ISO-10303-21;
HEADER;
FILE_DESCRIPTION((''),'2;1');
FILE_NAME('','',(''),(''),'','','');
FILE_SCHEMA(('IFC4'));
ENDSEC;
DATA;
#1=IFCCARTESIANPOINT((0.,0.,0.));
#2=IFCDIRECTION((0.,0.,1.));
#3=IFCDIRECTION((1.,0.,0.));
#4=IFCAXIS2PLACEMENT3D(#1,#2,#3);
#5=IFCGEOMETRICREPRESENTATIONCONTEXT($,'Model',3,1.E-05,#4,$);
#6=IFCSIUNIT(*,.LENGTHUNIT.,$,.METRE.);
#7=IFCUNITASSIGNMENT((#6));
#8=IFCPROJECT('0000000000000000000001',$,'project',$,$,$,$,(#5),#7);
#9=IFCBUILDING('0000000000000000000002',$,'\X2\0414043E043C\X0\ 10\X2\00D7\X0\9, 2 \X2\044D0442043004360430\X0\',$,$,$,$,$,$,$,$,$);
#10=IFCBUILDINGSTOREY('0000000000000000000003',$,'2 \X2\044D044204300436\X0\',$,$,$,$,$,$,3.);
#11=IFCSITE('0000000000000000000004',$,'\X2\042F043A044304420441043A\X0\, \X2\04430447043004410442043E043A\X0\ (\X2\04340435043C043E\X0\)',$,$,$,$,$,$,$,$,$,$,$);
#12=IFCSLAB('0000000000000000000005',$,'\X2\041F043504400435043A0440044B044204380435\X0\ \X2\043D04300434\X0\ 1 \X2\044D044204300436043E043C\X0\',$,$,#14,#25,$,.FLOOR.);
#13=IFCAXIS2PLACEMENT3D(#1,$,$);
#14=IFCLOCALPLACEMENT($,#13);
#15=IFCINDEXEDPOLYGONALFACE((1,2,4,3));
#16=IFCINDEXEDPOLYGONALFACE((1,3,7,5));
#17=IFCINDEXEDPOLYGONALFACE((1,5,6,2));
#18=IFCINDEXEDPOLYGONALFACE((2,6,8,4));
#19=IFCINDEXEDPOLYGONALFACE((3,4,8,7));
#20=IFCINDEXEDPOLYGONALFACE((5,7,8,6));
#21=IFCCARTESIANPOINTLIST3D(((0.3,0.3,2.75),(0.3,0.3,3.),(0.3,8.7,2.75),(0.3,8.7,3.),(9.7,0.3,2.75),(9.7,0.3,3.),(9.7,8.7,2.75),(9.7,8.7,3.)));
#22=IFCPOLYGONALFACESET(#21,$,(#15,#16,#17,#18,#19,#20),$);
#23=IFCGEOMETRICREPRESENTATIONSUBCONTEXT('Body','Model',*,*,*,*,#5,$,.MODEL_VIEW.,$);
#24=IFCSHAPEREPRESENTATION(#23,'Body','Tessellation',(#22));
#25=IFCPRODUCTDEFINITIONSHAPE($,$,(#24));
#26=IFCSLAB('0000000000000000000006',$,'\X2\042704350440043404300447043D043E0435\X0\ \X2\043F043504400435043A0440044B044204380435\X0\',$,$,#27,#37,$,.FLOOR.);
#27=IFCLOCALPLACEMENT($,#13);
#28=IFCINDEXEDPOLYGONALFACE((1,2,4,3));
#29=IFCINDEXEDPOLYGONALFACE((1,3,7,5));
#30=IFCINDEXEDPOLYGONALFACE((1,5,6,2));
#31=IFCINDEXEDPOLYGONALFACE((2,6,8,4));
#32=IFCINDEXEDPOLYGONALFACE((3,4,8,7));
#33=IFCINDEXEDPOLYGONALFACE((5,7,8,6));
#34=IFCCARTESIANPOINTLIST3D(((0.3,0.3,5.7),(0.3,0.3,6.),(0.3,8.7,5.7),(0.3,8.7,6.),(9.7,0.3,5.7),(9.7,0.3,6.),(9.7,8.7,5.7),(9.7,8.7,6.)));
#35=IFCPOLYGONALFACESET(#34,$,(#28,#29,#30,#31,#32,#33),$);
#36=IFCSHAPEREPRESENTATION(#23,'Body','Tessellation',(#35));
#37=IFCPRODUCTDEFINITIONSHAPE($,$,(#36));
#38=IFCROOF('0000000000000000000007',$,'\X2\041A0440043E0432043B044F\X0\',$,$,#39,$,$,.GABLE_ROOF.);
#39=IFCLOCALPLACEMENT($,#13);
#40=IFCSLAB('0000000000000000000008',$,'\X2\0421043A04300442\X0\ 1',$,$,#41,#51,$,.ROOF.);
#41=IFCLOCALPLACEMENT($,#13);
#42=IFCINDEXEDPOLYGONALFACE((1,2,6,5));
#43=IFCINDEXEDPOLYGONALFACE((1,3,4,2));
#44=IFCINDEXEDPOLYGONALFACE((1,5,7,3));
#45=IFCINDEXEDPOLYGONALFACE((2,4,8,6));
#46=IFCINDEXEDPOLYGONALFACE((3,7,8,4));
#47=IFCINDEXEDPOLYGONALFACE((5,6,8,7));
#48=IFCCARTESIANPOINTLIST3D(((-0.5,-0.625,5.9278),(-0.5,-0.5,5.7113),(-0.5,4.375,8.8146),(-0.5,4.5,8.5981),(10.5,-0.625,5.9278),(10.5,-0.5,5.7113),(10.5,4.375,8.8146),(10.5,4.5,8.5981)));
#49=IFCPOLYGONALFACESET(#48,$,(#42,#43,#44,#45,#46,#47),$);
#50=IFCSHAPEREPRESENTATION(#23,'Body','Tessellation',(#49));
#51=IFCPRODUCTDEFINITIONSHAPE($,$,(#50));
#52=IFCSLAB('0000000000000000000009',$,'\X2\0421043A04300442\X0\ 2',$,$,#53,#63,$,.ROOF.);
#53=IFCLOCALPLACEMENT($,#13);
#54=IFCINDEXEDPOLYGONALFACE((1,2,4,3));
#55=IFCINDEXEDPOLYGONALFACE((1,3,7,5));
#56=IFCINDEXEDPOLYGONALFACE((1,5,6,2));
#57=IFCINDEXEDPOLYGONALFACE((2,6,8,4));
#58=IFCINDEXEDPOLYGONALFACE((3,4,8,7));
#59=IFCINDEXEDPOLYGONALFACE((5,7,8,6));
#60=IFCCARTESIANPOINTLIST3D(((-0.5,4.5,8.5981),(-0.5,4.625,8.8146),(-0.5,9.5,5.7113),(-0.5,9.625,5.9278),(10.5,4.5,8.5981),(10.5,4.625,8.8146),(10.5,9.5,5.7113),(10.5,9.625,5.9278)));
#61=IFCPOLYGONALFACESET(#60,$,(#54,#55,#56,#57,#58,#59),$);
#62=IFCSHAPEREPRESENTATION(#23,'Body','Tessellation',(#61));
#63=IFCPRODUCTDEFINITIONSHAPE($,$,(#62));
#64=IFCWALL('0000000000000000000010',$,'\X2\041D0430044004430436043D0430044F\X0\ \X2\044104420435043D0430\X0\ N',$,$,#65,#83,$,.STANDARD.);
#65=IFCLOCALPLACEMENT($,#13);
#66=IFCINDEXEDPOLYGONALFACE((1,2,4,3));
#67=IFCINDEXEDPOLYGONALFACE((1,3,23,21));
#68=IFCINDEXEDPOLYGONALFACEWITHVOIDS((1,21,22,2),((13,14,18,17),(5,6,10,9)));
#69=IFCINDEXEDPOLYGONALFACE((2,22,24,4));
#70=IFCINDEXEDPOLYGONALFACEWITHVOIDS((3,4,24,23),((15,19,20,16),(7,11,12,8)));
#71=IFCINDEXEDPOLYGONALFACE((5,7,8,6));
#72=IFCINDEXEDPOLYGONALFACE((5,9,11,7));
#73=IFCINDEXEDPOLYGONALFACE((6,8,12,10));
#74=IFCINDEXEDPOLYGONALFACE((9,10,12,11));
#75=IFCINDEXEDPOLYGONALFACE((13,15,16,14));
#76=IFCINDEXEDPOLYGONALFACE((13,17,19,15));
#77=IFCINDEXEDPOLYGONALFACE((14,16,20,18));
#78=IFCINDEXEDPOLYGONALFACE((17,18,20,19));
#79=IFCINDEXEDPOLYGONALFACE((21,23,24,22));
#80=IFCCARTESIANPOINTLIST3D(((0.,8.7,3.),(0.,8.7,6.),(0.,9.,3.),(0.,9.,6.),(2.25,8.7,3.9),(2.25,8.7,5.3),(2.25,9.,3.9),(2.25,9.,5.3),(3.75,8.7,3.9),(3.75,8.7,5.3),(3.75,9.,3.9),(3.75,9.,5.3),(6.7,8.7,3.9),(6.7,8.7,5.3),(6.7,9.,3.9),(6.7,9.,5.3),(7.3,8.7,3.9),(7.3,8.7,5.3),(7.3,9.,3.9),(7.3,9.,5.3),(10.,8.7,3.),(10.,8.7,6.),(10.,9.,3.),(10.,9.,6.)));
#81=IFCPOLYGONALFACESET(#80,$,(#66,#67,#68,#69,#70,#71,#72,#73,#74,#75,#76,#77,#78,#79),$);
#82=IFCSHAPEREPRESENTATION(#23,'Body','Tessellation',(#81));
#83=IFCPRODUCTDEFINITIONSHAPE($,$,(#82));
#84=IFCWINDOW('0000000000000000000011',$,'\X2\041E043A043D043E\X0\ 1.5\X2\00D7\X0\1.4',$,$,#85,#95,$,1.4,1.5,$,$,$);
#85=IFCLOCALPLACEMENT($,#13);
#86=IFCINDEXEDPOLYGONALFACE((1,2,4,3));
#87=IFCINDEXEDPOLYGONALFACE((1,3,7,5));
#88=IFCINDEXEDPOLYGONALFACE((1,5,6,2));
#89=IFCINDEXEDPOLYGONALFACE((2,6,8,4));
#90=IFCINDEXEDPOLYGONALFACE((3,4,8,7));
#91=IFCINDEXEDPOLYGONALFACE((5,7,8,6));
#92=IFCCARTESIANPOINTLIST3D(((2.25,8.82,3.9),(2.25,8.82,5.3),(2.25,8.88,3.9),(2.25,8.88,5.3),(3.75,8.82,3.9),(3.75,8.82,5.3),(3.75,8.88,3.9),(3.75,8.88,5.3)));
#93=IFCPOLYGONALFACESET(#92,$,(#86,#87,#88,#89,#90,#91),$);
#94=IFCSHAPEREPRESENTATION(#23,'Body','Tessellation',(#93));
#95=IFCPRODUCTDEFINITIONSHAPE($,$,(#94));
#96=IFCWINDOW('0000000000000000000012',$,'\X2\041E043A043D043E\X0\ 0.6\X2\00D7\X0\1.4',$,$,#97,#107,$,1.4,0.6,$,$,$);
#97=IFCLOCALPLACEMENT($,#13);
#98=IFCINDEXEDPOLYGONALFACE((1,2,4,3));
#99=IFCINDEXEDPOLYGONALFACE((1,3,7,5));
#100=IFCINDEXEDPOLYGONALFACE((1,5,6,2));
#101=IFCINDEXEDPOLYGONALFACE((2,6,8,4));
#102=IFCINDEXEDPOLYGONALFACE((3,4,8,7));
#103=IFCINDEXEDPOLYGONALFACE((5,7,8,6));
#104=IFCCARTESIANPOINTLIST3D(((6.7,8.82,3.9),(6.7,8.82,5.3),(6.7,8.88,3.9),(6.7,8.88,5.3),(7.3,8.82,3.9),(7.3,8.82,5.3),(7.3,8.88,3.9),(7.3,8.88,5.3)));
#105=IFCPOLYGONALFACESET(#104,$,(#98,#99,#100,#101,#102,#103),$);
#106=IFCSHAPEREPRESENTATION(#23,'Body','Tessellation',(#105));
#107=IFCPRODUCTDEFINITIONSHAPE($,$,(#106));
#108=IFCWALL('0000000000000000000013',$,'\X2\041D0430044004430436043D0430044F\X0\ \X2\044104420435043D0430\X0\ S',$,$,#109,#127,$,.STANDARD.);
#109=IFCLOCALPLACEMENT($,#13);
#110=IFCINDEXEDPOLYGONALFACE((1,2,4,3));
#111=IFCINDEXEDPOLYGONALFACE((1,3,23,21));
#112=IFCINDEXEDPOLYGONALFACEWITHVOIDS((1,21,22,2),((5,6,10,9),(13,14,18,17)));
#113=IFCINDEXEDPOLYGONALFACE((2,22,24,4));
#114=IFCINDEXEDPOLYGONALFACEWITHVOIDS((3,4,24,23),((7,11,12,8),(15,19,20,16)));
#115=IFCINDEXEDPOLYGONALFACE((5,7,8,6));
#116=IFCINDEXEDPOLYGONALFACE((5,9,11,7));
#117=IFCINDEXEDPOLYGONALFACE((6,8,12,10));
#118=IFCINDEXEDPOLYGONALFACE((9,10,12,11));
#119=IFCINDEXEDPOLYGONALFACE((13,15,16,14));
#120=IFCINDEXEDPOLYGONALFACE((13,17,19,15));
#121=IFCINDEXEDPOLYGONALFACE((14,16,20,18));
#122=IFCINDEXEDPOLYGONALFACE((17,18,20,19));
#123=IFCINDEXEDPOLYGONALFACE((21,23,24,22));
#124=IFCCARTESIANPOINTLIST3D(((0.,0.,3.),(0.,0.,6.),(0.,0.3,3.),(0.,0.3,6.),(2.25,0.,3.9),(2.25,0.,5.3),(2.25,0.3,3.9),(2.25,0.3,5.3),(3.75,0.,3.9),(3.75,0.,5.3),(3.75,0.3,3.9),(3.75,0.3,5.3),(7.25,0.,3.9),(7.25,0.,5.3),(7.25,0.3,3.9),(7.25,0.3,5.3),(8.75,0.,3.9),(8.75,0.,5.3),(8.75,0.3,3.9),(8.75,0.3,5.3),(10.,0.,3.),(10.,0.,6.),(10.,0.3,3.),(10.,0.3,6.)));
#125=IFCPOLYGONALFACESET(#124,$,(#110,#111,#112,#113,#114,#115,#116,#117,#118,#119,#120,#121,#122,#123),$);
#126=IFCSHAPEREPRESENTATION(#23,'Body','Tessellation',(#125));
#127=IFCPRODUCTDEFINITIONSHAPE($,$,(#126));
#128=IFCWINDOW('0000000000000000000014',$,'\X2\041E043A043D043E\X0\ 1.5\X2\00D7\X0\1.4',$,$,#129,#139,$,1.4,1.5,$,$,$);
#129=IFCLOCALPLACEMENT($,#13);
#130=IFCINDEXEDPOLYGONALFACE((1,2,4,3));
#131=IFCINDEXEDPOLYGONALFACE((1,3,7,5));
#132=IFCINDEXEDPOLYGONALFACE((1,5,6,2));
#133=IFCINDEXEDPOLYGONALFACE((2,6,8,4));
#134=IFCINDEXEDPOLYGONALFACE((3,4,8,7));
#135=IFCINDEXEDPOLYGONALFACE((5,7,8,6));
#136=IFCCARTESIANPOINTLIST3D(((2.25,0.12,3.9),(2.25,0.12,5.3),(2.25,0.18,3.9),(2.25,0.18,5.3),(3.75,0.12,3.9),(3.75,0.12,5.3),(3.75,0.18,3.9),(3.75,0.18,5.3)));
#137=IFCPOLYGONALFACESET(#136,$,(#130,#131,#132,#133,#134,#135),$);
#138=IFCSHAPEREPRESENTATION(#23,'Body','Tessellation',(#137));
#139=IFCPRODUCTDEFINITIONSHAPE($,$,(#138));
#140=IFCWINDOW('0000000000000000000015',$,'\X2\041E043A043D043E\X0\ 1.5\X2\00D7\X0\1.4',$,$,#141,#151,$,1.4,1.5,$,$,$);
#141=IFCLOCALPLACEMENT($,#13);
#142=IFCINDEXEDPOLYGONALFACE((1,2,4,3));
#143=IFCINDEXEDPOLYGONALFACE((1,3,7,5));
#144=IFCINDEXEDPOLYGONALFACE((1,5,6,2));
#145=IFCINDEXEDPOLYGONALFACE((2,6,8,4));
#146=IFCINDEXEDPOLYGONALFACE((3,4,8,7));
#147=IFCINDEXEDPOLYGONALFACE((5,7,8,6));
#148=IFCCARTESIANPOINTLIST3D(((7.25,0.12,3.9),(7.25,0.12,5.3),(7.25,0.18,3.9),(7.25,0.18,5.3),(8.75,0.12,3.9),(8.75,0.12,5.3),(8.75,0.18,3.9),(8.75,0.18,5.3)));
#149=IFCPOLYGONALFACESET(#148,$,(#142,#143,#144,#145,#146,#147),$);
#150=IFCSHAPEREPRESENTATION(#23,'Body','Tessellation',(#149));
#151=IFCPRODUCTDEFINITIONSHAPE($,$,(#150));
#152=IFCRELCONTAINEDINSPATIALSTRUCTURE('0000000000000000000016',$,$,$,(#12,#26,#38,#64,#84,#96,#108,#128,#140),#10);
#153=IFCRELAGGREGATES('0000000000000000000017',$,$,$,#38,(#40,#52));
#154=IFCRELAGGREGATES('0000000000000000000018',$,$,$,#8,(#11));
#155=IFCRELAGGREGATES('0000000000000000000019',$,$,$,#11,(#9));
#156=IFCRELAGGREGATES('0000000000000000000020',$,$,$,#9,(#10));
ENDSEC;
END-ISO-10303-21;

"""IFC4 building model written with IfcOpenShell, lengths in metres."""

from ifc_helpers import new_model, si_unit, frame, origin_with_axes, place, context, subcontext, project, spatial, indexed_curve, outline, extrude, element, fill, aggregate, save


model = new_model("IFC4")

# Units and contexts
model_context = context("Model", 3, precision=1e-05, world=origin_with_axes())
body_context = subcontext(model_context, "Body", "Model", "MODEL_VIEW")
ifc_project = project(units=[si_unit("LENGTHUNIT", "METRE")], contexts=[model_context])

# Site, building, storey
site = spatial("IfcSite", under=ifc_project, Name="Якутск, участок (демо)")
building = spatial("IfcBuilding", under=site, Name="Дом 10×9, 2 этажа")
storey = spatial("IfcBuildingStorey", under=building, Name="2 этаж", Elevation=3.0)

# Slabs
slab_1_placement = place(None, frame((0.0, 0.0, 2.75), z_axis=(0.0, 0.0, 1.0), x_axis=(1.0, 0.0, 0.0)))
element("IfcSlab", 1, at=slab_1_placement, inside=storey, Name="Перекрытие над 1 этажом", PredefinedType="FLOOR", context=body_context, shape_type="SweptSolid", body=[
    extrude(outline(indexed_curve([(0.3, 0.3), (9.7, 0.3), (9.7, 8.7), (0.3, 8.7)])), None, (0.0, 0.0, 1.0), 0.25),
])
slab_2_placement = place(None, frame((0.0, 0.0, 5.7), z_axis=(0.0, 0.0, 1.0), x_axis=(1.0, 0.0, 0.0)))
element("IfcSlab", 2, at=slab_2_placement, inside=storey, Name="Чердачное перекрытие", PredefinedType="FLOOR", context=body_context, shape_type="SweptSolid", body=[
    extrude(outline(indexed_curve([(0.3, 0.3), (9.7, 0.3), (9.7, 8.7), (0.3, 8.7)])), None, (0.0, 0.0, 1.0), 0.3),
])

# Roof, slabs
roof = element("IfcRoof", 3, inside=storey, Name="Кровля", PredefinedType="GABLE_ROOF")
slab_3_placement = place(None, frame((-0.5, -0.5, 5.7113), z_axis=(0.0, -0.5, 0.866025), x_axis=(1.0, 0.0, 0.0)))
slab_3 = element("IfcSlab", 4, at=slab_3_placement, Name="Скат 1", PredefinedType="ROOF", context=body_context, shape_type="SweptSolid", body=[
    extrude(outline(indexed_curve([(0.0, 0.0), (11.0, 0.0), (11.0, 5.7735), (0.0, 5.7735)])), None, (0.0, 0.0, 1.0), 0.25),
])
slab_4_placement = place(None, frame((10.5, 9.5, 5.7113), z_axis=(0.0, 0.5, 0.866025), x_axis=(-1.0, 0.0, 0.0)))
slab_4 = element("IfcSlab", 5, at=slab_4_placement, Name="Скат 2", PredefinedType="ROOF", context=body_context, shape_type="SweptSolid", body=[
    extrude(outline(indexed_curve([(0.0, 0.0), (11.0, 0.0), (11.0, 5.7735), (0.0, 5.7735)])), None, (0.0, 0.0, 1.0), 0.25),
])
aggregate(roof, [slab_3, slab_4])

# Walls, openings, windows
wall_1_placement = place(None, frame((0.0, 8.7, 3.0), z_axis=(0.0, 0.0, 1.0), x_axis=(1.0, 0.0, 0.0)))
wall_1 = element("IfcWall", 6, at=wall_1_placement, inside=storey, Name="Наружная стена N", PredefinedType="STANDARD", context=body_context, shape_type="SweptSolid", body=[
    extrude(outline(indexed_curve([(0.0, 0.0), (0.0, 0.3), (10.0, 0.3), (10.0, 0.0), (0.0, 0.0)], self_intersect=False)), origin_with_axes(), (0.0, 0.0, 1.0), 3.0),
])
opening_1_placement = place(wall_1_placement, frame((2.25, -0.05, 0.9), z_axis=(0.0, 0.0, 1.0), x_axis=(1.0, 0.0, 0.0)))
opening_1 = element("IfcOpeningElement", 7, at=opening_1_placement, cuts=wall_1, context=body_context, shape_type="SweptSolid", body=[
    extrude(outline(indexed_curve([(0.0, 0.0), (0.0, 0.4), (1.5, 0.4), (1.5, 0.0), (0.0, 0.0)], self_intersect=False)), origin_with_axes(), (0.0, 0.0, 1.0), 1.4),
])
opening_2_placement = place(wall_1_placement, frame((6.7, -0.05, 0.9), z_axis=(0.0, 0.0, 1.0), x_axis=(1.0, 0.0, 0.0)))
opening_2 = element("IfcOpeningElement", 8, at=opening_2_placement, cuts=wall_1, context=body_context, shape_type="SweptSolid", body=[
    extrude(outline(indexed_curve([(0.0, 0.0), (0.0, 0.4), (0.6, 0.4), (0.6, 0.0), (0.0, 0.0)], self_intersect=False)), origin_with_axes(), (0.0, 0.0, 1.0), 1.4),
])
window_1_placement = place(opening_1_placement, frame((0.0, 0.17, 0.0), z_axis=(0.0, 0.0, 1.0), x_axis=(1.0, 0.0, 0.0)))
window_1 = element("IfcWindow", 9, at=window_1_placement, inside=storey, Name="Окно 1.5×1.4", OverallHeight=1.4, OverallWidth=1.5, context=body_context, shape_type="SweptSolid", body=[
    extrude(outline(indexed_curve([(0.0, 0.0), (0.0, 0.06), (1.5, 0.06), (1.5, 0.0), (0.0, 0.0)], self_intersect=False)), origin_with_axes(), (0.0, 0.0, 1.0), 1.4),
])
fill(opening_1, window_1)
window_2_placement = place(opening_2_placement, frame((0.0, 0.17, 0.0), z_axis=(0.0, 0.0, 1.0), x_axis=(1.0, 0.0, 0.0)))
window_2 = element("IfcWindow", 10, at=window_2_placement, inside=storey, Name="Окно 0.6×1.4", OverallHeight=1.4, OverallWidth=0.6, context=body_context, shape_type="SweptSolid", body=[
    extrude(outline(indexed_curve([(0.0, 0.0), (0.0, 0.06), (0.6, 0.06), (0.6, 0.0), (0.0, 0.0)], self_intersect=False)), origin_with_axes(), (0.0, 0.0, 1.0), 1.4),
])
fill(opening_2, window_2)
wall_2_placement = place(None, frame((0.0, 0.0, 3.0), z_axis=(0.0, 0.0, 1.0), x_axis=(1.0, 0.0, 0.0)))
wall_2 = element("IfcWall", 11, at=wall_2_placement, inside=storey, Name="Наружная стена S", PredefinedType="STANDARD", context=body_context, shape_type="SweptSolid", body=[
    extrude(outline(indexed_curve([(0.0, 0.0), (0.0, 0.3), (10.0, 0.3), (10.0, 0.0), (0.0, 0.0)], self_intersect=False)), origin_with_axes(), (0.0, 0.0, 1.0), 3.0),
])
opening_3_placement = place(wall_2_placement, frame((2.25, -0.05, 0.9), z_axis=(0.0, 0.0, 1.0), x_axis=(1.0, 0.0, 0.0)))
opening_3 = element("IfcOpeningElement", 12, at=opening_3_placement, cuts=wall_2, context=body_context, shape_type="SweptSolid", body=[
    extrude(outline(indexed_curve([(0.0, 0.0), (0.0, 0.4), (1.5, 0.4), (1.5, 0.0), (0.0, 0.0)], self_intersect=False)), origin_with_axes(), (0.0, 0.0, 1.0), 1.4),
])
opening_4_placement = place(wall_2_placement, frame((7.25, -0.05, 0.9), z_axis=(0.0, 0.0, 1.0), x_axis=(1.0, 0.0, 0.0)))
opening_4 = element("IfcOpeningElement", 13, at=opening_4_placement, cuts=wall_2, context=body_context, shape_type="SweptSolid", body=[
    extrude(outline(indexed_curve([(0.0, 0.0), (0.0, 0.4), (1.5, 0.4), (1.5, 0.0), (0.0, 0.0)], self_intersect=False)), origin_with_axes(), (0.0, 0.0, 1.0), 1.4),
])
window_3_placement = place(opening_3_placement, frame((0.0, 0.17, 0.0), z_axis=(0.0, 0.0, 1.0), x_axis=(1.0, 0.0, 0.0)))
window_3 = element("IfcWindow", 14, at=window_3_placement, inside=storey, Name="Окно 1.5×1.4", OverallHeight=1.4, OverallWidth=1.5, context=body_context, shape_type="SweptSolid", body=[
    extrude(outline(indexed_curve([(0.0, 0.0), (0.0, 0.06), (1.5, 0.06), (1.5, 0.0), (0.0, 0.0)], self_intersect=False)), origin_with_axes(), (0.0, 0.0, 1.0), 1.4),
])
fill(opening_3, window_3)
window_4_placement = place(opening_4_placement, frame((0.0, 0.17, 0.0), z_axis=(0.0, 0.0, 1.0), x_axis=(1.0, 0.0, 0.0)))
window_4 = element("IfcWindow", 15, at=window_4_placement, inside=storey, Name="Окно 1.5×1.4", OverallHeight=1.4, OverallWidth=1.5, context=body_context, shape_type="SweptSolid", body=[
    extrude(outline(indexed_curve([(0.0, 0.0), (0.0, 0.06), (1.5, 0.06), (1.5, 0.0), (0.0, 0.0)], self_intersect=False)), origin_with_axes(), (0.0, 0.0, 1.0), 1.4),
])
fill(opening_4, window_4)

save(model, "model.ifc")
